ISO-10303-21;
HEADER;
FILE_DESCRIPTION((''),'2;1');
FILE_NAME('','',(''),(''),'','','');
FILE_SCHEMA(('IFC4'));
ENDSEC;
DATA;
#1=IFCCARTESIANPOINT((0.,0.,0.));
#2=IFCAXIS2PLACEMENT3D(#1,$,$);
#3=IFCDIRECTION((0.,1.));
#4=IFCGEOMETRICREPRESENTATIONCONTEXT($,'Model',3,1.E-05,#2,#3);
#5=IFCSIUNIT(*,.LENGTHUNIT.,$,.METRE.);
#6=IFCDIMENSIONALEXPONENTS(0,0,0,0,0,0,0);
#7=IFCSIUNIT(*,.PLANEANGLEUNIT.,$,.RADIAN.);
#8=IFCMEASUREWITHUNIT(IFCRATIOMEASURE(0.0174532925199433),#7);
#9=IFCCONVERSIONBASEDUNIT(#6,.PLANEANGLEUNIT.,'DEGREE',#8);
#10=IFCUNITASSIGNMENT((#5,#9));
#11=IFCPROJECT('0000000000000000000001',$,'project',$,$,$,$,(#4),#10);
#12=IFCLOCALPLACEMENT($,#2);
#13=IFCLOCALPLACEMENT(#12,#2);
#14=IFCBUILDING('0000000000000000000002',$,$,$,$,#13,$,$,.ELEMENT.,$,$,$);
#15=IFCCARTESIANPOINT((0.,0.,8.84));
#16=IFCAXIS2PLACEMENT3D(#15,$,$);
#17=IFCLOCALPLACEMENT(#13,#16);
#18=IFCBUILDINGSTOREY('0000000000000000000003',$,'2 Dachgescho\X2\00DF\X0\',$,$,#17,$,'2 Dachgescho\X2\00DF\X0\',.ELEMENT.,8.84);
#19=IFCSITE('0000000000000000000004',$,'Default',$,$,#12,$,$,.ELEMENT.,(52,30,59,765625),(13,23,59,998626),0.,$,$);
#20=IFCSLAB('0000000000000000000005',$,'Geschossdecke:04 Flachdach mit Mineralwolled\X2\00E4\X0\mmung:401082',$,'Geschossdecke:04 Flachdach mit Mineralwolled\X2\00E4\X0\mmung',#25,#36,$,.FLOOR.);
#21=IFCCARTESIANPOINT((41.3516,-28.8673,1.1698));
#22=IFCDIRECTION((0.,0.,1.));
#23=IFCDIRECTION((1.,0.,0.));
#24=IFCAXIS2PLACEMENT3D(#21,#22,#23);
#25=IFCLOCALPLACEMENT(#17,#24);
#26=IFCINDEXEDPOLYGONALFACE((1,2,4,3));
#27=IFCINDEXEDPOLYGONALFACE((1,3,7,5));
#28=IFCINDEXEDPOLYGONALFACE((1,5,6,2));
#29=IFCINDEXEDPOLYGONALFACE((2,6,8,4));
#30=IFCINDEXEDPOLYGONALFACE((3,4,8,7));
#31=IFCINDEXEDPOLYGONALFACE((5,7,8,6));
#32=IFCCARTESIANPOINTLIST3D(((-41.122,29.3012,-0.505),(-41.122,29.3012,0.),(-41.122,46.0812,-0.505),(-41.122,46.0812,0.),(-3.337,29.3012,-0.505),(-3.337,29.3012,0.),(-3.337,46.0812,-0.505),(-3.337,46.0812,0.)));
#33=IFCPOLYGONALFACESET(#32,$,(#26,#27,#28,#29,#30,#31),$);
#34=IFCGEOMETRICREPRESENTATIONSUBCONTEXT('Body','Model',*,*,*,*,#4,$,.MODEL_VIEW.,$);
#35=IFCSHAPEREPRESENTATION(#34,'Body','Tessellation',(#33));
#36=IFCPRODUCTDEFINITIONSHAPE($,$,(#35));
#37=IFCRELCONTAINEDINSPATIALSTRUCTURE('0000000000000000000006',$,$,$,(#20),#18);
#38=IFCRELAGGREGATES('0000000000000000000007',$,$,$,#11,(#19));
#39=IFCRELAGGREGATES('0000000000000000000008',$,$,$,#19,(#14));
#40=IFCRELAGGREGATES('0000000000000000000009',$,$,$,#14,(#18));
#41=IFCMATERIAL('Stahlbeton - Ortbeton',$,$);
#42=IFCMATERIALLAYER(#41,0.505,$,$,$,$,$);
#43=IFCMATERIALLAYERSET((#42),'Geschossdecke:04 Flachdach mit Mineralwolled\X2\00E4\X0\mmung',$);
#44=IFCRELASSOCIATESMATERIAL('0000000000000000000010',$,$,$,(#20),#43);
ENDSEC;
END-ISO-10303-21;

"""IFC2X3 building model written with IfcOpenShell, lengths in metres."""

from ifc_helpers import new_model, entity, si_unit, converted_unit, direction, frame, frame_2d, origin, place, context, subcontext, project, spatial, rectangle, extrude, material, layer, layer_set, layer_usage, element, save


model = new_model("IFC2X3")

# Units and contexts
model_context = context("Model", 3, precision=1e-05, world=origin(), true_north=direction((0.0, 1.0)))
body_context = subcontext(model_context, "Body", "Model", "MODEL_VIEW")
ifc_project = project(units=[si_unit("LENGTHUNIT", "METRE"), converted_unit("PLANEANGLEUNIT", "DEGREE", entity("IfcRatioMeasure", 0.0174532925199433), si_unit("PLANEANGLEUNIT", "RADIAN"), dimensions=[0, 0, 0, 0, 0, 0, 0])], contexts=[model_context])

# Site, building, storey
site_placement = place(None, origin())
site = spatial("IfcSite", under=ifc_project, at=site_placement, Name="Default", CompositionType="ELEMENT", RefLatitude=(52, 30, 59, 765625), RefLongitude=(13, 23, 59, 998626), RefElevation=0.0)
building_placement = place(site_placement, origin())
building = spatial("IfcBuilding", under=site, at=building_placement, CompositionType="ELEMENT")
storey_placement = place(building_placement, frame((0.0, 0.0, 8.84)))
storey = spatial("IfcBuildingStorey", under=building, at=storey_placement, Name="2 Dachgeschoß", LongName="2 Dachgeschoß", CompositionType="ELEMENT", Elevation=8.84)

# Slab
ifc_material_1 = material(Name="Stahlbeton - Ortbeton")
ifc_layer_1 = layer(ifc_material_1, 0.505)
ifc_layer_set_1 = layer_set([ifc_layer_1], Name="Geschossdecke:04 Flachdach mit Mineralwolledämmung")
ifc_layer_usage_1 = layer_usage(ifc_layer_set_1, "AXIS3", "POSITIVE", 0.0)
slab_placement = place(storey_placement, frame((41.3516, -28.8673, 1.1698), z_axis=(0.0, 0.0, 1.0), x_axis=(1.0, 0.0, 0.0)))
element("IfcSlab", 1, at=slab_placement, inside=storey, material=ifc_layer_usage_1, Name="Geschossdecke:04 Flachdach mit Mineralwolledämmung:401082", ObjectType="Geschossdecke:04 Flachdach mit Mineralwolledämmung", PredefinedType="FLOOR", context=body_context, shape_type="SweptSolid", body=[
    extrude(rectangle(XDim=16.78, YDim=37.785, at=frame_2d((0.0, 0.0), x_axis=(1.0, 0.0))), frame((-22.2295, 37.6912, 0.0), z_axis=(0.0, 0.0, -1.0), x_axis=(0.0, 1.0, 0.0)), (0.0, 0.0, 1.0), 0.505),
])

save(model, "model.ifc")
